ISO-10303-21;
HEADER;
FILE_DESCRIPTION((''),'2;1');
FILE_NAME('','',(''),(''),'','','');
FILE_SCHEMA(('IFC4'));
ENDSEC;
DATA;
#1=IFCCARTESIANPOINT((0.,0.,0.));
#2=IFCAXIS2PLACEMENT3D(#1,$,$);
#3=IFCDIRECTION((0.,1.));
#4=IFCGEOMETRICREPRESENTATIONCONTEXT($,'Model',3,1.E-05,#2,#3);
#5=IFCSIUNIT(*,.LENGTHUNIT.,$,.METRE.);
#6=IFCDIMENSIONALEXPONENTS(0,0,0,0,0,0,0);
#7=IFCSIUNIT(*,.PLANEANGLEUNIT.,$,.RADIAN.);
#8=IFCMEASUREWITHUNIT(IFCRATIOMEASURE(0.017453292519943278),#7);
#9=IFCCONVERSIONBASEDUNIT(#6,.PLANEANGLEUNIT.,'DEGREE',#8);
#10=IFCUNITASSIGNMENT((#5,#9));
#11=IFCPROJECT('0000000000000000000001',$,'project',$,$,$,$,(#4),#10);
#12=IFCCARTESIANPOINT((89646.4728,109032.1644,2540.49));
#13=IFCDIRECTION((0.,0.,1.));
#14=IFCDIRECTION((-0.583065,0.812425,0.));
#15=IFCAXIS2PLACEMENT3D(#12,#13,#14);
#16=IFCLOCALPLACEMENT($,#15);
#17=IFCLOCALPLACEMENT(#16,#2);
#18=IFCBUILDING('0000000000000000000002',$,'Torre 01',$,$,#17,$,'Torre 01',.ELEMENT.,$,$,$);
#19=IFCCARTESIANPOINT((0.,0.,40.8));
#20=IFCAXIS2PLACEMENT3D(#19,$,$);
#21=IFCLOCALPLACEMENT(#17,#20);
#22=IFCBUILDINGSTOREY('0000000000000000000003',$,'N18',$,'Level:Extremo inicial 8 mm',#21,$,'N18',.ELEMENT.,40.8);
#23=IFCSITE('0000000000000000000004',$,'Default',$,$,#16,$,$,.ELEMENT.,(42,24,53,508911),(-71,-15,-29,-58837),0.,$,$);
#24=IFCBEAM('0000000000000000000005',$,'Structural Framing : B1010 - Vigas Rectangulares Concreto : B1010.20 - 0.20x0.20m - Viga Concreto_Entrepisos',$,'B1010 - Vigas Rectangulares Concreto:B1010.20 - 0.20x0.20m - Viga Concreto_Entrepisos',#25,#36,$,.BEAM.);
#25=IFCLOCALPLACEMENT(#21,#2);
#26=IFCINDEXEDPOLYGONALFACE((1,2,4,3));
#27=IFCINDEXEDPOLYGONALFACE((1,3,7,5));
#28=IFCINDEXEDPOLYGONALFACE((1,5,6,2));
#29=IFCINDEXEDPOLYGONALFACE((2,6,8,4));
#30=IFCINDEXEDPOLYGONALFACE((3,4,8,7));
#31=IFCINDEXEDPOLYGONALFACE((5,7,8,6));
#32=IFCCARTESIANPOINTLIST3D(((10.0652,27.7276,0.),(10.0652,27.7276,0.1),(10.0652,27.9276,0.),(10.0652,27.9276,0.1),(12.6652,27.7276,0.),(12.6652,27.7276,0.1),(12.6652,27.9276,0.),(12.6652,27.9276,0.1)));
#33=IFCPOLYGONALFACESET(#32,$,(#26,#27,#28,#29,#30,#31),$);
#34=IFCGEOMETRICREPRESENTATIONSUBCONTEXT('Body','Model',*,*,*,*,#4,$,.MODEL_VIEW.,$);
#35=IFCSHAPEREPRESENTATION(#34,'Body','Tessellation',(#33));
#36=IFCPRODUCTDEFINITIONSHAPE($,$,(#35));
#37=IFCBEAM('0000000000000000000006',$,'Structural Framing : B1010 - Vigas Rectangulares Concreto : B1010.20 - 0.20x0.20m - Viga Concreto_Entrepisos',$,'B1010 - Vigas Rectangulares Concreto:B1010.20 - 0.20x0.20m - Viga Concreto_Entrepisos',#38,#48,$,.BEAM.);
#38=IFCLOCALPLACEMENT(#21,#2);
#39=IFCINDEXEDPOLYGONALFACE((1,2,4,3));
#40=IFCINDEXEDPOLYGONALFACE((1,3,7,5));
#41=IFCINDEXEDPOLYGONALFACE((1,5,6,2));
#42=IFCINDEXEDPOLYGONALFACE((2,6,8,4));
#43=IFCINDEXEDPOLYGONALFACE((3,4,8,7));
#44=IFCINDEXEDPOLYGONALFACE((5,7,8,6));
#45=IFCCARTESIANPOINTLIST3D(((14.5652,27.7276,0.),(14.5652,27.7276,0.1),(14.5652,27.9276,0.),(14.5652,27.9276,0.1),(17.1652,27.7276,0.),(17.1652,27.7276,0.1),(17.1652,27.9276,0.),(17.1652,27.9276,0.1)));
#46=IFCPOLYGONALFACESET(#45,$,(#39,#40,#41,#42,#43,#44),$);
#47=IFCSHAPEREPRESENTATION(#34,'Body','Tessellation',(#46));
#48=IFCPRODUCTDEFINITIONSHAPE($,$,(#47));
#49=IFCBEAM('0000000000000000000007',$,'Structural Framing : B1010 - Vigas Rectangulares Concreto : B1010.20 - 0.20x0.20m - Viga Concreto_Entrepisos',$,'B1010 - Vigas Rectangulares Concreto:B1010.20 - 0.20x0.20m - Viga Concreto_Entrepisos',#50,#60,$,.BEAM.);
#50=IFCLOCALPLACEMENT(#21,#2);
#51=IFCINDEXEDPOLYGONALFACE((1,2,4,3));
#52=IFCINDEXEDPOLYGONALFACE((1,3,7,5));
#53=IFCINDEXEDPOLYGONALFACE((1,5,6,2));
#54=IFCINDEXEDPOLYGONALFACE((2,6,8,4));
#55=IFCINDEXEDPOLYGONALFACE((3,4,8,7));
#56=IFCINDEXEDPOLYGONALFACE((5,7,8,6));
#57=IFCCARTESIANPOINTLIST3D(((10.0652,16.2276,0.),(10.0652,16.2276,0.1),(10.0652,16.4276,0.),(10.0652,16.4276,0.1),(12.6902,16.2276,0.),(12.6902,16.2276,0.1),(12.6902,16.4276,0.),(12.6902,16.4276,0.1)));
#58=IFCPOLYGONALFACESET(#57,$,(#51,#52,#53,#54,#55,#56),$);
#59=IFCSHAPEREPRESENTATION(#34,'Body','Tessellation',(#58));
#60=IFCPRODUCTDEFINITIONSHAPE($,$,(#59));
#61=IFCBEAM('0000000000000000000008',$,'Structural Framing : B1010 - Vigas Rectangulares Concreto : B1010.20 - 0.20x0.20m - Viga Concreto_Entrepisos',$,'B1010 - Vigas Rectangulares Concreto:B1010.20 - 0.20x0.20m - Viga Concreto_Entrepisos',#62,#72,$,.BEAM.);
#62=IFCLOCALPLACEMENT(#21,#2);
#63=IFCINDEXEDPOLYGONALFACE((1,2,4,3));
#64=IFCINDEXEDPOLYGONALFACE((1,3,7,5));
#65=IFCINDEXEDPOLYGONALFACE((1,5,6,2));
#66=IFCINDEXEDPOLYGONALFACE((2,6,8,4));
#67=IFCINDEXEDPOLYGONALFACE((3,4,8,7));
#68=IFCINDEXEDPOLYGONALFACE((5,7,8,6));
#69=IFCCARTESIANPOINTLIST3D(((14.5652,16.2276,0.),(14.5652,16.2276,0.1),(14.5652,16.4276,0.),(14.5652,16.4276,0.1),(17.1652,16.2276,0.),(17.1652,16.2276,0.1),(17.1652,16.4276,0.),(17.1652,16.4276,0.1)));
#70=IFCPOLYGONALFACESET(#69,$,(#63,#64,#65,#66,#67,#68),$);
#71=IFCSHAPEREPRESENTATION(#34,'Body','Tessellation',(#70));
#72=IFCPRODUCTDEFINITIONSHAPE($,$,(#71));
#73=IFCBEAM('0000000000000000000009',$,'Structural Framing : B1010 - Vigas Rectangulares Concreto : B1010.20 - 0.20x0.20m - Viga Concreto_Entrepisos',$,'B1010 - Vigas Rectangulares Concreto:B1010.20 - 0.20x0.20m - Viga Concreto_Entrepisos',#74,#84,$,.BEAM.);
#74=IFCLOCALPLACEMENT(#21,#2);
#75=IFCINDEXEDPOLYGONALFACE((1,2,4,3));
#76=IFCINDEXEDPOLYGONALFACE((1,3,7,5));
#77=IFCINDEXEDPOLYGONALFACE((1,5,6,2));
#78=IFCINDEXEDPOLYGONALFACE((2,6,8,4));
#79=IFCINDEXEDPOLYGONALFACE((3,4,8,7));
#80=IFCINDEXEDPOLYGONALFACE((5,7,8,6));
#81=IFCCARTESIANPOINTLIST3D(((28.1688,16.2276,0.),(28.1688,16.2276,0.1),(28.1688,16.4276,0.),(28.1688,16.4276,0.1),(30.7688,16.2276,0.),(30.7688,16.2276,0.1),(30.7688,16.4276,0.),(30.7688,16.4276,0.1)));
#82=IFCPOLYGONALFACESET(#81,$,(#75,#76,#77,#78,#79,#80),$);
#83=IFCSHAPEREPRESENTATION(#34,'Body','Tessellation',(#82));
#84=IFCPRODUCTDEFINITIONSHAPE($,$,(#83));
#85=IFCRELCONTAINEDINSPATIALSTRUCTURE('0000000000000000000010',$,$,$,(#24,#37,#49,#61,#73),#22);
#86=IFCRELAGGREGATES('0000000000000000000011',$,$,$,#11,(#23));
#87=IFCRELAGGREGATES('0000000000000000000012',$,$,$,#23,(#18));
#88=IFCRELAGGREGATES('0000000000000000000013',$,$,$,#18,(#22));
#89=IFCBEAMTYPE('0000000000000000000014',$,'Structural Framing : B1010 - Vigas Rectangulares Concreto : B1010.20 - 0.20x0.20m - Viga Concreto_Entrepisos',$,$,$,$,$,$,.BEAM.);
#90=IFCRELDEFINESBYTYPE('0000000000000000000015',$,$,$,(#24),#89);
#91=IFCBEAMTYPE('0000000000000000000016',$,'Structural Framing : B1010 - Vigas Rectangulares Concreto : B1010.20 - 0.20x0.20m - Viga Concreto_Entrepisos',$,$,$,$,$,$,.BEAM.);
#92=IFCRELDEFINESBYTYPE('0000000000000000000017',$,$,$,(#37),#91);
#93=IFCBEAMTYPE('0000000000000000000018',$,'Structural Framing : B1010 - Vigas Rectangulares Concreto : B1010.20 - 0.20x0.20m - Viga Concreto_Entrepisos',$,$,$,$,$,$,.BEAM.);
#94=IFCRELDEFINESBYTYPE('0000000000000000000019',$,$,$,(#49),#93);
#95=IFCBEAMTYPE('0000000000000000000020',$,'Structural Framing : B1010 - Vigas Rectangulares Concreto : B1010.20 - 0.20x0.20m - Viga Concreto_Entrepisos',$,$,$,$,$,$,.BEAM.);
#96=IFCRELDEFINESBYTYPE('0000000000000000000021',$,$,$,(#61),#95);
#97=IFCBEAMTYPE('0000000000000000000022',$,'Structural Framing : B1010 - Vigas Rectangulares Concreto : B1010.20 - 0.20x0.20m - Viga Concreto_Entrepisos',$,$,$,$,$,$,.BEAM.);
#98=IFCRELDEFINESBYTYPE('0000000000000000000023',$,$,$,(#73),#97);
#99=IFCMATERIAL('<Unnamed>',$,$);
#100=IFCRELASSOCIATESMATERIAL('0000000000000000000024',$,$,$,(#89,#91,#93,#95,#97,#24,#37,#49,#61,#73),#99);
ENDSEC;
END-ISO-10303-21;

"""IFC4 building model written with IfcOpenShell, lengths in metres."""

from ifc_helpers import new_model, entity, si_unit, converted_unit, direction, frame, frame_2d, origin, place, context, subcontext, project, spatial, polyline, segment, composite_curve, rectangle, outline, extrude, source, transform, mapped, material, material_profile, profile_set, profile_usage, type_object, type_shapes, element, save


model = new_model("IFC4")

# Units and contexts
model_context = context("Model", 3, precision=1e-05, world=origin(), true_north=direction((0.0, 1.0)))
body_context = subcontext(model_context, "Body", "Model", "MODEL_VIEW")
ifc_project = project(units=[si_unit("LENGTHUNIT", "METRE"), converted_unit("PLANEANGLEUNIT", "DEGREE", entity("IfcRatioMeasure", 0.017453292519943278), si_unit("PLANEANGLEUNIT", "RADIAN"), dimensions=[0, 0, 0, 0, 0, 0, 0])], contexts=[model_context])

# Site, building, storey
site_placement = place(None, frame((89646.4728, 109032.1644, 2540.49), z_axis=(0.0, 0.0, 1.0), x_axis=(-0.583065, 0.812425, 0.0)))
site = spatial("IfcSite", under=ifc_project, at=site_placement, Name="Default", CompositionType="ELEMENT", RefLatitude=(42, 24, 53, 508911), RefLongitude=(-71, -15, -29, -58837), RefElevation=0.0)
building_placement = place(site_placement, origin())
building = spatial("IfcBuilding", under=site, at=building_placement, Name="Torre 01", LongName="Torre 01", CompositionType="ELEMENT")
storey_placement = place(building_placement, frame((0.0, 0.0, 40.8)))
storey = spatial("IfcBuildingStorey", under=building, at=storey_placement, Name="N18", ObjectType="Level:Extremo inicial 8 mm", LongName="N18", CompositionType="ELEMENT", Elevation=40.8)

# Beams
ifc_material = material(Name="<Unnamed>")
ifc_material_profile_1 = material_profile(ifc_material, outline(composite_curve([segment(polyline([(-0.1, 0.0, 0.0), (-0.1, 0.1, 0.0)]), True, "CONTINUOUS"), segment(polyline([(-0.1, 0.1, 0.0), (0.1, 0.1, 0.0)]), True, "CONTINUOUS"), segment(polyline([(0.1, 0.1, 0.0), (0.1, 0.0, 0.0)]), True, "CONTINUOUS"), segment(polyline([(0.1, 0.0, 0.0), (-0.1, 0.0, 0.0)]), True, "CONTINUOUS")], self_intersect=False), kind="CURVE"), Name="B1010.20 - 0.20x0.20m - Viga Concreto_Entrepisos")
ifc_material_profile_2 = material_profile(ifc_material, outline(composite_curve([segment(polyline([(-1.3, -0.1, 0.1), (-1.3, 0.1, 0.1)]), True, "CONTINUOUS"), segment(polyline([(-1.3, 0.1, 0.1), (-1.3, 0.1, -0.1)]), True, "CONTINUOUS"), segment(polyline([(-1.3, 0.1, -0.1), (-1.3, -0.1, -0.1)]), True, "CONTINUOUS"), segment(polyline([(-1.3, -0.1, -0.1), (-1.3, -0.1, 0.1)]), True, "CONTINUOUS")], self_intersect=False), kind="CURVE"), Name="B1010.20 - 0.20x0.20m - Viga Concreto_Entrepisos")
ifc_profile_set = profile_set([ifc_material_profile_1, ifc_material_profile_2], Name="B1010.20 - 0.20x0.20m - Viga Concreto_Entrepisos")
ifc_profile_usage_1 = profile_usage(ifc_profile_set, cardinal=8)
beam_type_1 = type_object("IfcBeamType", Name="Structural Framing : B1010 - Vigas Rectangulares Concreto : B1010.20 - 0.20x0.20m - Viga Concreto_Entrepisos", PredefinedType="BEAM", material=ifc_profile_set)
shared_shape_1 = source(origin(), body_context, "Body", "SweptSolid", [
    extrude(rectangle(XDim=0.1, YDim=0.2, at=frame_2d((0.0, 0.0), x_axis=(1.0, 0.0))), frame((10.0652, 27.8276, 40.85), z_axis=(1.0, 0.0, 0.0), x_axis=(0.0, 0.0, -1.0)), (0.0, 0.0, 1.0), 2.6),
])
type_shapes(beam_type_1, [shared_shape_1])
beam_1_placement = place(storey_placement, frame((0.0, 0.0, -40.8)))
element("IfcBeam", 1, at=beam_1_placement, inside=storey, type_object=beam_type_1, material=ifc_profile_usage_1, Name="Structural Framing : B1010 - Vigas Rectangulares Concreto : B1010.20 - 0.20x0.20m - Viga Concreto_Entrepisos", ObjectType="B1010 - Vigas Rectangulares Concreto:B1010.20 - 0.20x0.20m - Viga Concreto_Entrepisos", PredefinedType="BEAM", context=body_context, shape_type="MappedRepresentation", body=[
    mapped(shared_shape_1, transform((0.0, 0.0, 0.0), scale=1.0)),
])
ifc_profile_usage_2 = profile_usage(ifc_profile_set, cardinal=8)
beam_type_2 = type_object("IfcBeamType", Name="Structural Framing : B1010 - Vigas Rectangulares Concreto : B1010.20 - 0.20x0.20m - Viga Concreto_Entrepisos", PredefinedType="BEAM", material=ifc_profile_set)
shared_shape_2 = source(origin(), body_context, "Body", "SweptSolid", [
    extrude(rectangle(XDim=0.1, YDim=0.2, at=frame_2d((0.0, 0.0), x_axis=(1.0, 0.0))), frame((17.1652, 27.8276, 40.85), z_axis=(-1.0, 0.0, 0.0), x_axis=(0.0, 0.0, -1.0)), (0.0, 0.0, 1.0), 2.6),
])
type_shapes(beam_type_2, [shared_shape_2])
beam_2_placement = place(storey_placement, frame((0.0, 0.0, -40.8)))
element("IfcBeam", 2, at=beam_2_placement, inside=storey, type_object=beam_type_2, material=ifc_profile_usage_2, Name="Structural Framing : B1010 - Vigas Rectangulares Concreto : B1010.20 - 0.20x0.20m - Viga Concreto_Entrepisos", ObjectType="B1010 - Vigas Rectangulares Concreto:B1010.20 - 0.20x0.20m - Viga Concreto_Entrepisos", PredefinedType="BEAM", context=body_context, shape_type="MappedRepresentation", body=[
    mapped(shared_shape_2, transform((0.0, 0.0, 0.0), scale=1.0)),
])
ifc_profile_usage_3 = profile_usage(ifc_profile_set, cardinal=8)
beam_type_3 = type_object("IfcBeamType", Name="Structural Framing : B1010 - Vigas Rectangulares Concreto : B1010.20 - 0.20x0.20m - Viga Concreto_Entrepisos", PredefinedType="BEAM", material=ifc_profile_set)
shared_shape_3 = source(origin(), body_context, "Body", "SweptSolid", [
    extrude(rectangle(XDim=0.1, YDim=0.2, at=frame_2d((0.0, 0.0), x_axis=(1.0, 0.0))), frame((10.0652, 16.3276, 40.85), z_axis=(1.0, 0.0, 0.0), x_axis=(0.0, 0.0, -1.0)), (0.0, 0.0, 1.0), 2.625),
])
type_shapes(beam_type_3, [shared_shape_3])
beam_3_placement = place(storey_placement, frame((0.0, 0.0, -40.8)))
element("IfcBeam", 3, at=beam_3_placement, inside=storey, type_object=beam_type_3, material=ifc_profile_usage_3, Name="Structural Framing : B1010 - Vigas Rectangulares Concreto : B1010.20 - 0.20x0.20m - Viga Concreto_Entrepisos", ObjectType="B1010 - Vigas Rectangulares Concreto:B1010.20 - 0.20x0.20m - Viga Concreto_Entrepisos", PredefinedType="BEAM", context=body_context, shape_type="MappedRepresentation", body=[
    mapped(shared_shape_3, transform((0.0, 0.0, 0.0), scale=1.0)),
])
ifc_profile_usage_4 = profile_usage(ifc_profile_set, cardinal=8)
beam_type_4 = type_object("IfcBeamType", Name="Structural Framing : B1010 - Vigas Rectangulares Concreto : B1010.20 - 0.20x0.20m - Viga Concreto_Entrepisos", PredefinedType="BEAM", material=ifc_profile_set)
shared_shape_4 = source(origin(), body_context, "Body", "SweptSolid", [
    extrude(rectangle(XDim=0.1, YDim=0.2, at=frame_2d((0.0, 0.0), x_axis=(1.0, 0.0))), frame((17.1652, 16.3276, 40.85), z_axis=(-1.0, 0.0, 0.0), x_axis=(0.0, 0.0, -1.0)), (0.0, 0.0, 1.0), 2.6),
])
type_shapes(beam_type_4, [shared_shape_4])
beam_4_placement = place(storey_placement, frame((0.0, 0.0, -40.8)))
element("IfcBeam", 4, at=beam_4_placement, inside=storey, type_object=beam_type_4, material=ifc_profile_usage_4, Name="Structural Framing : B1010 - Vigas Rectangulares Concreto : B1010.20 - 0.20x0.20m - Viga Concreto_Entrepisos", ObjectType="B1010 - Vigas Rectangulares Concreto:B1010.20 - 0.20x0.20m - Viga Concreto_Entrepisos", PredefinedType="BEAM", context=body_context, shape_type="MappedRepresentation", body=[
    mapped(shared_shape_4, transform((0.0, 0.0, 0.0), scale=1.0)),
])
ifc_profile_usage_5 = profile_usage(ifc_profile_set, cardinal=8)
beam_type_5 = type_object("IfcBeamType", Name="Structural Framing : B1010 - Vigas Rectangulares Concreto : B1010.20 - 0.20x0.20m - Viga Concreto_Entrepisos", PredefinedType="BEAM", material=ifc_profile_set)
shared_shape_5 = source(origin(), body_context, "Body", "SweptSolid", [
    extrude(rectangle(XDim=0.1, YDim=0.2, at=frame_2d((0.0, 0.0), x_axis=(1.0, 0.0))), frame((28.1688, 16.3276, 40.85), z_axis=(1.0, 0.0, 0.0), x_axis=(0.0, 0.0, -1.0)), (0.0, 0.0, 1.0), 2.6),
])
type_shapes(beam_type_5, [shared_shape_5])
beam_5_placement = place(storey_placement, frame((0.0, 0.0, -40.8)))
element("IfcBeam", 5, at=beam_5_placement, inside=storey, type_object=beam_type_5, material=ifc_profile_usage_5, Name="Structural Framing : B1010 - Vigas Rectangulares Concreto : B1010.20 - 0.20x0.20m - Viga Concreto_Entrepisos", ObjectType="B1010 - Vigas Rectangulares Concreto:B1010.20 - 0.20x0.20m - Viga Concreto_Entrepisos", PredefinedType="BEAM", context=body_context, shape_type="MappedRepresentation", body=[
    mapped(shared_shape_5, transform((0.0, 0.0, 0.0), scale=1.0)),
])

save(model, "model.ifc")
